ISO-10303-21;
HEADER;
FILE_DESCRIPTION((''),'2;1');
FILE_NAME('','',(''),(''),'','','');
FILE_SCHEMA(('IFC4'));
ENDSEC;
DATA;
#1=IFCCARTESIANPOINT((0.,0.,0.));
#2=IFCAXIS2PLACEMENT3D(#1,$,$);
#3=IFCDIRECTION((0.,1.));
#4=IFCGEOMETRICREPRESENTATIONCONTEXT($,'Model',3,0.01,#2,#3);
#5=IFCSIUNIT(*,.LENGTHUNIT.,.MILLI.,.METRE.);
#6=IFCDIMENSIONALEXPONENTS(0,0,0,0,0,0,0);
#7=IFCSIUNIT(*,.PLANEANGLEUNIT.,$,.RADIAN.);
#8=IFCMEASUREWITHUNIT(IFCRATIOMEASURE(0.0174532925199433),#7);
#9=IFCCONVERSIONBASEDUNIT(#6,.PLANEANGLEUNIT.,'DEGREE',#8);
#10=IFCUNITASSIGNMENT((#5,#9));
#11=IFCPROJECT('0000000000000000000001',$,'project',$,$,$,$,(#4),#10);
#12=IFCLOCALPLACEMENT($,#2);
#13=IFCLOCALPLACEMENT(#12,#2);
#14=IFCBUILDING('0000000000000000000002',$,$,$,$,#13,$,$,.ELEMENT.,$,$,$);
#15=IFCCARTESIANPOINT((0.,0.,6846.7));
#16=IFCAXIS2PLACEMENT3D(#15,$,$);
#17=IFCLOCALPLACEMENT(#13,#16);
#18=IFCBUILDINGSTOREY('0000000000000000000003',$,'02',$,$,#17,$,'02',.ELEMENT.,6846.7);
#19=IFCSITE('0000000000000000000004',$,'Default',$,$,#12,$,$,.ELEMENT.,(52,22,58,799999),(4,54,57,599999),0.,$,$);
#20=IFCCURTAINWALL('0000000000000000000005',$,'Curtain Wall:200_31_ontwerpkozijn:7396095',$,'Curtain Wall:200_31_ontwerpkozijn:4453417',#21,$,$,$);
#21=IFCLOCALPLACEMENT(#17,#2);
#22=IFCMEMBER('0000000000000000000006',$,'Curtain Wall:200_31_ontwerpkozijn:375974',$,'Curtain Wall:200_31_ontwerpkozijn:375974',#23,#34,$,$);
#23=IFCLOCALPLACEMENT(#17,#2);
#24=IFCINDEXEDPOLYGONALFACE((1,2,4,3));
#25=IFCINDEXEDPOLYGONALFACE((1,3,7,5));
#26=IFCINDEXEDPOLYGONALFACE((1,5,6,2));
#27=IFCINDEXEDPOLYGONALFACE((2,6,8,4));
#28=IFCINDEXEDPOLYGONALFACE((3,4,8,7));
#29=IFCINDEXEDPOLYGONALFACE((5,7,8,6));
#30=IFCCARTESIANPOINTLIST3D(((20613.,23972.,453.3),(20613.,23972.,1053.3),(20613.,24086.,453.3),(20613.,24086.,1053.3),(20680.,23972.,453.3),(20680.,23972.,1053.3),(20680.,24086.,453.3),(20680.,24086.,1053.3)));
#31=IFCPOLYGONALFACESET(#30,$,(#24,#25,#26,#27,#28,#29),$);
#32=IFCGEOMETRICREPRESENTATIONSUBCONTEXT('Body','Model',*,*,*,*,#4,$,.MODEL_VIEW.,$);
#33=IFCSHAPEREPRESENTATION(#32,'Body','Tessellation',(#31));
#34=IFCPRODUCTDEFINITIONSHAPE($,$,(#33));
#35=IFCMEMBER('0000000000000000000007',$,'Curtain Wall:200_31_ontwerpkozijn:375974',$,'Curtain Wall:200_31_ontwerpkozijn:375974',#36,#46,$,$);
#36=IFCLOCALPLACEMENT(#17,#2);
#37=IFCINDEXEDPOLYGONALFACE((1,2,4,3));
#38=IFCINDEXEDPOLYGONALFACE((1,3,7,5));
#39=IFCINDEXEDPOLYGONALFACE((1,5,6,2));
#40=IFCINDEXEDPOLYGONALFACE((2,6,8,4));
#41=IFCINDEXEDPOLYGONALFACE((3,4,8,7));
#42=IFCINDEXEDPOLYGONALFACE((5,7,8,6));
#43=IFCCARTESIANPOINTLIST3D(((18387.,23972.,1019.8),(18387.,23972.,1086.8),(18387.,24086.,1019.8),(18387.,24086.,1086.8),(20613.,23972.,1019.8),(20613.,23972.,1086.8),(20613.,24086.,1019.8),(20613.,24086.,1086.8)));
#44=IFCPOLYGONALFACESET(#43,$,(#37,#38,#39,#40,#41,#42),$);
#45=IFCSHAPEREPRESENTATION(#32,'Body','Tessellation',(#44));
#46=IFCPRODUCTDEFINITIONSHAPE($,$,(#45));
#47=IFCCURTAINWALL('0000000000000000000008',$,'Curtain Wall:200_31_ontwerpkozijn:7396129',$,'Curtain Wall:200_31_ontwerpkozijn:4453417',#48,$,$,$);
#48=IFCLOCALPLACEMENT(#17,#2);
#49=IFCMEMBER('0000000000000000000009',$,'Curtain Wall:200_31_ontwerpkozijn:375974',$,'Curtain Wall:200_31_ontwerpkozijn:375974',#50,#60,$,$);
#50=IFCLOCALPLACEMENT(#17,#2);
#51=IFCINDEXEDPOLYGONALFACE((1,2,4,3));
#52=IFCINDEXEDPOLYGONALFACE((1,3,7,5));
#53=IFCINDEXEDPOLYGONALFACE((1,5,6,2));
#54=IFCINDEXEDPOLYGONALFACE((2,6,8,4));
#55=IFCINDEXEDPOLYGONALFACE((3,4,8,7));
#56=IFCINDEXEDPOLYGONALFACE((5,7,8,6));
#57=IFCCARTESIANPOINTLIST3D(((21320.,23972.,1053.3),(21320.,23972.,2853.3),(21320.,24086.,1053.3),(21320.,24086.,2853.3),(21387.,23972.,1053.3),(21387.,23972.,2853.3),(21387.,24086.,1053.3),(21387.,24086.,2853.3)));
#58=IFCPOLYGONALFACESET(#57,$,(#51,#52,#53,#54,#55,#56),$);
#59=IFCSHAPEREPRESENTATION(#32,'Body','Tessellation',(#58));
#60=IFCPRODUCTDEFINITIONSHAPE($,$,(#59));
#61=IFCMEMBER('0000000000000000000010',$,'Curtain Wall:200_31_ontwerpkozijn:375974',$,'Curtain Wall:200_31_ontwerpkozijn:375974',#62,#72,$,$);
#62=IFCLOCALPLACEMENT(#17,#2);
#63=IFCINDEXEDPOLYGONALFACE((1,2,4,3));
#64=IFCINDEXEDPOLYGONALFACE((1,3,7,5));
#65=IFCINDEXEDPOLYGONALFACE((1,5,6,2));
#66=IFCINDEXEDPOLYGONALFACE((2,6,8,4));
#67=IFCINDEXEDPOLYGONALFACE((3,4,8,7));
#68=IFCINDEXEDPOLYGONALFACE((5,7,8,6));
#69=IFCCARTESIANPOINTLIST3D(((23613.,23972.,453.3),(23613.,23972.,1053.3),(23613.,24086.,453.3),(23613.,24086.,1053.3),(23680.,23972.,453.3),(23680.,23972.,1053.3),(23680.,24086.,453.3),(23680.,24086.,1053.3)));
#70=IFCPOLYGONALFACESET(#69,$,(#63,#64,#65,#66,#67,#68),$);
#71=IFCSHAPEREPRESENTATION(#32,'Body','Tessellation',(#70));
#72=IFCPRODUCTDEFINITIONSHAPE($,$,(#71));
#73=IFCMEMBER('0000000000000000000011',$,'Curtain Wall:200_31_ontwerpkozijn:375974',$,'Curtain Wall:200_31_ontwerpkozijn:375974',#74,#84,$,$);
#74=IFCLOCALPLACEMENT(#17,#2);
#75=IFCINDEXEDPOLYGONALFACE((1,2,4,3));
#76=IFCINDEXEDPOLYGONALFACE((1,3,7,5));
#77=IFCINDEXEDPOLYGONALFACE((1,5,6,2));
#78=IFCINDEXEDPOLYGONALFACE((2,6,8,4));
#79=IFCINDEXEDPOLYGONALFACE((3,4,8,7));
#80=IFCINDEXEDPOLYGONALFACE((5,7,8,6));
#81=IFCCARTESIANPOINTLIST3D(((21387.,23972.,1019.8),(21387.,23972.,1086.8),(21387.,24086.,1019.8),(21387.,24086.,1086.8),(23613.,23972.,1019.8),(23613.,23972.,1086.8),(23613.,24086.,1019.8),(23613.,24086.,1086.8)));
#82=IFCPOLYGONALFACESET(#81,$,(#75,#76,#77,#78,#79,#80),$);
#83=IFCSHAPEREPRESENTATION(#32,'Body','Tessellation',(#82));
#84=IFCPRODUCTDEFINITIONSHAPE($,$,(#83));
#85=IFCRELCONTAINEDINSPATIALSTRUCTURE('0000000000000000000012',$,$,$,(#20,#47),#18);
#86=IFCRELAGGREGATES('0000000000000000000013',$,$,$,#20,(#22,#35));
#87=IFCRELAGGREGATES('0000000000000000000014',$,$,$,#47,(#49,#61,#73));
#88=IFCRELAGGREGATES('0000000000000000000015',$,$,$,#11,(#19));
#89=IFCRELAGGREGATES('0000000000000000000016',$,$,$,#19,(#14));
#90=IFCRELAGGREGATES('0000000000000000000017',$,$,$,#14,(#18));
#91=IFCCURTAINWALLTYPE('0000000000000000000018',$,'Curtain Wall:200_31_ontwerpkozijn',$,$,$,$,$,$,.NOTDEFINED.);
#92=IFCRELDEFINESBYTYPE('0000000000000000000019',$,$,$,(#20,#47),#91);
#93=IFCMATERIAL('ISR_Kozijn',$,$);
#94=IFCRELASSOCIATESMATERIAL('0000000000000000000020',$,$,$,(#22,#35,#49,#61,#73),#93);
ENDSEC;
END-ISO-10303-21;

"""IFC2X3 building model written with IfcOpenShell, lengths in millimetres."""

from ifc_helpers import new_model, entity, si_unit, converted_unit, direction, frame, frame_2d, origin, origin_2d_with_axis, place, context, subcontext, project, spatial, rectangle, extrude, material, type_object, element, aggregate, save


model = new_model("IFC2X3")

# Units and contexts
model_context = context("Model", 3, precision=0.01, world=origin(), true_north=direction((0.0, 1.0)))
body_context = subcontext(model_context, "Body", "Model", "MODEL_VIEW")
ifc_project = project(units=[si_unit("LENGTHUNIT", "METRE", prefix="MILLI"), converted_unit("PLANEANGLEUNIT", "DEGREE", entity("IfcRatioMeasure", 0.0174532925199433), si_unit("PLANEANGLEUNIT", "RADIAN"), dimensions=[0, 0, 0, 0, 0, 0, 0])], contexts=[model_context])

# Site, building, storey
site_placement = place(None, origin())
site = spatial("IfcSite", under=ifc_project, at=site_placement, Name="Default", CompositionType="ELEMENT", RefLatitude=(52, 22, 58, 799999), RefLongitude=(4, 54, 57, 599999), RefElevation=0.0)
building_placement = place(site_placement, origin())
building = spatial("IfcBuilding", under=site, at=building_placement, CompositionType="ELEMENT")
storey_placement = place(building_placement, frame((0.0, 0.0, 6846.7)))
storey = spatial("IfcBuildingStorey", under=building, at=storey_placement, Name="02", LongName="02", CompositionType="ELEMENT", Elevation=6846.7)

# Curtain walls, members
curtain_wall_type = type_object("IfcCurtainWallType", Name="Curtain Wall:200_31_ontwerpkozijn", PredefinedType="NOTDEFINED")
ifc_material = material(Name="ISR_Kozijn")
curtain_wall_1_placement = place(storey_placement, frame((0.0, 0.0, -6846.7)))
curtain_wall_1 = element("IfcCurtainWall", 1, at=curtain_wall_1_placement, inside=storey, type_object=curtain_wall_type, Name="Curtain Wall:200_31_ontwerpkozijn:7396095", ObjectType="Curtain Wall:200_31_ontwerpkozijn:4453417")
member_1_placement = place(curtain_wall_1_placement, frame((0.0, 0.0, 6846.7)))
member_1 = element("IfcMember", 2, at=member_1_placement, material=ifc_material, Name="Curtain Wall:200_31_ontwerpkozijn:375974", ObjectType="Curtain Wall:200_31_ontwerpkozijn:375974", context=body_context, shape_type="SweptSolid", body=[
    extrude(rectangle(XDim=67.0, YDim=114.0, at=origin_2d_with_axis()), frame((20646.5, 24029.0, 1053.3), z_axis=(0.0, 0.0, -1.0), x_axis=(-1.0, 0.0, 0.0)), (0.0, 0.0, 1.0), 600.0),
])
member_2_placement = place(curtain_wall_1_placement, frame((0.0, 0.0, 6846.7)))
member_2 = element("IfcMember", 3, at=member_2_placement, material=ifc_material, Name="Curtain Wall:200_31_ontwerpkozijn:375974", ObjectType="Curtain Wall:200_31_ontwerpkozijn:375974", context=body_context, shape_type="SweptSolid", body=[
    extrude(rectangle(XDim=67.0, YDim=114.0, at=frame_2d((0.0, 0.0), x_axis=(1.0, 0.0))), frame((18387.0, 24029.0, 1053.3), z_axis=(1.0, 0.0, 0.0), x_axis=(0.0, 0.0, -1.0)), (0.0, 0.0, 1.0), 2226.0),
])
aggregate(curtain_wall_1, [member_1, member_2])
curtain_wall_2_placement = place(storey_placement, frame((0.0, 0.0, -6846.7)))
curtain_wall_2 = element("IfcCurtainWall", 4, at=curtain_wall_2_placement, inside=storey, type_object=curtain_wall_type, Name="Curtain Wall:200_31_ontwerpkozijn:7396129", ObjectType="Curtain Wall:200_31_ontwerpkozijn:4453417")
member_3_placement = place(curtain_wall_2_placement, frame((0.0, 0.0, 6846.7)))
member_3 = element("IfcMember", 5, at=member_3_placement, material=ifc_material, Name="Curtain Wall:200_31_ontwerpkozijn:375974", ObjectType="Curtain Wall:200_31_ontwerpkozijn:375974", context=body_context, shape_type="SweptSolid", body=[
    extrude(rectangle(XDim=67.0, YDim=114.0, at=origin_2d_with_axis()), frame((21353.5, 24029.0, 1053.3), z_axis=(0.0, 0.0, 1.0), x_axis=(-1.0, 0.0, 0.0)), (0.0, 0.0, 1.0), 1800.0),
])
member_4_placement = place(curtain_wall_2_placement, frame((0.0, 0.0, 6846.7)))
member_4 = element("IfcMember", 6, at=member_4_placement, material=ifc_material, Name="Curtain Wall:200_31_ontwerpkozijn:375974", ObjectType="Curtain Wall:200_31_ontwerpkozijn:375974", context=body_context, shape_type="SweptSolid", body=[
    extrude(rectangle(XDim=67.0, YDim=114.0, at=origin_2d_with_axis()), frame((23646.5, 24029.0, 1053.3), z_axis=(0.0, 0.0, -1.0), x_axis=(-1.0, 0.0, 0.0)), (0.0, 0.0, 1.0), 600.0),
])
member_5_placement = place(curtain_wall_2_placement, frame((0.0, 0.0, 6846.7)))
member_5 = element("IfcMember", 7, at=member_5_placement, material=ifc_material, Name="Curtain Wall:200_31_ontwerpkozijn:375974", ObjectType="Curtain Wall:200_31_ontwerpkozijn:375974", context=body_context, shape_type="SweptSolid", body=[
    extrude(rectangle(XDim=67.0, YDim=114.0, at=frame_2d((0.0, 0.0), x_axis=(1.0, 0.0))), frame((21387.0, 24029.0, 1053.3), z_axis=(1.0, 0.0, 0.0), x_axis=(0.0, 0.0, -1.0)), (0.0, 0.0, 1.0), 2226.0),
])
aggregate(curtain_wall_2, [member_3, member_4, member_5])

save(model, "model.ifc")
